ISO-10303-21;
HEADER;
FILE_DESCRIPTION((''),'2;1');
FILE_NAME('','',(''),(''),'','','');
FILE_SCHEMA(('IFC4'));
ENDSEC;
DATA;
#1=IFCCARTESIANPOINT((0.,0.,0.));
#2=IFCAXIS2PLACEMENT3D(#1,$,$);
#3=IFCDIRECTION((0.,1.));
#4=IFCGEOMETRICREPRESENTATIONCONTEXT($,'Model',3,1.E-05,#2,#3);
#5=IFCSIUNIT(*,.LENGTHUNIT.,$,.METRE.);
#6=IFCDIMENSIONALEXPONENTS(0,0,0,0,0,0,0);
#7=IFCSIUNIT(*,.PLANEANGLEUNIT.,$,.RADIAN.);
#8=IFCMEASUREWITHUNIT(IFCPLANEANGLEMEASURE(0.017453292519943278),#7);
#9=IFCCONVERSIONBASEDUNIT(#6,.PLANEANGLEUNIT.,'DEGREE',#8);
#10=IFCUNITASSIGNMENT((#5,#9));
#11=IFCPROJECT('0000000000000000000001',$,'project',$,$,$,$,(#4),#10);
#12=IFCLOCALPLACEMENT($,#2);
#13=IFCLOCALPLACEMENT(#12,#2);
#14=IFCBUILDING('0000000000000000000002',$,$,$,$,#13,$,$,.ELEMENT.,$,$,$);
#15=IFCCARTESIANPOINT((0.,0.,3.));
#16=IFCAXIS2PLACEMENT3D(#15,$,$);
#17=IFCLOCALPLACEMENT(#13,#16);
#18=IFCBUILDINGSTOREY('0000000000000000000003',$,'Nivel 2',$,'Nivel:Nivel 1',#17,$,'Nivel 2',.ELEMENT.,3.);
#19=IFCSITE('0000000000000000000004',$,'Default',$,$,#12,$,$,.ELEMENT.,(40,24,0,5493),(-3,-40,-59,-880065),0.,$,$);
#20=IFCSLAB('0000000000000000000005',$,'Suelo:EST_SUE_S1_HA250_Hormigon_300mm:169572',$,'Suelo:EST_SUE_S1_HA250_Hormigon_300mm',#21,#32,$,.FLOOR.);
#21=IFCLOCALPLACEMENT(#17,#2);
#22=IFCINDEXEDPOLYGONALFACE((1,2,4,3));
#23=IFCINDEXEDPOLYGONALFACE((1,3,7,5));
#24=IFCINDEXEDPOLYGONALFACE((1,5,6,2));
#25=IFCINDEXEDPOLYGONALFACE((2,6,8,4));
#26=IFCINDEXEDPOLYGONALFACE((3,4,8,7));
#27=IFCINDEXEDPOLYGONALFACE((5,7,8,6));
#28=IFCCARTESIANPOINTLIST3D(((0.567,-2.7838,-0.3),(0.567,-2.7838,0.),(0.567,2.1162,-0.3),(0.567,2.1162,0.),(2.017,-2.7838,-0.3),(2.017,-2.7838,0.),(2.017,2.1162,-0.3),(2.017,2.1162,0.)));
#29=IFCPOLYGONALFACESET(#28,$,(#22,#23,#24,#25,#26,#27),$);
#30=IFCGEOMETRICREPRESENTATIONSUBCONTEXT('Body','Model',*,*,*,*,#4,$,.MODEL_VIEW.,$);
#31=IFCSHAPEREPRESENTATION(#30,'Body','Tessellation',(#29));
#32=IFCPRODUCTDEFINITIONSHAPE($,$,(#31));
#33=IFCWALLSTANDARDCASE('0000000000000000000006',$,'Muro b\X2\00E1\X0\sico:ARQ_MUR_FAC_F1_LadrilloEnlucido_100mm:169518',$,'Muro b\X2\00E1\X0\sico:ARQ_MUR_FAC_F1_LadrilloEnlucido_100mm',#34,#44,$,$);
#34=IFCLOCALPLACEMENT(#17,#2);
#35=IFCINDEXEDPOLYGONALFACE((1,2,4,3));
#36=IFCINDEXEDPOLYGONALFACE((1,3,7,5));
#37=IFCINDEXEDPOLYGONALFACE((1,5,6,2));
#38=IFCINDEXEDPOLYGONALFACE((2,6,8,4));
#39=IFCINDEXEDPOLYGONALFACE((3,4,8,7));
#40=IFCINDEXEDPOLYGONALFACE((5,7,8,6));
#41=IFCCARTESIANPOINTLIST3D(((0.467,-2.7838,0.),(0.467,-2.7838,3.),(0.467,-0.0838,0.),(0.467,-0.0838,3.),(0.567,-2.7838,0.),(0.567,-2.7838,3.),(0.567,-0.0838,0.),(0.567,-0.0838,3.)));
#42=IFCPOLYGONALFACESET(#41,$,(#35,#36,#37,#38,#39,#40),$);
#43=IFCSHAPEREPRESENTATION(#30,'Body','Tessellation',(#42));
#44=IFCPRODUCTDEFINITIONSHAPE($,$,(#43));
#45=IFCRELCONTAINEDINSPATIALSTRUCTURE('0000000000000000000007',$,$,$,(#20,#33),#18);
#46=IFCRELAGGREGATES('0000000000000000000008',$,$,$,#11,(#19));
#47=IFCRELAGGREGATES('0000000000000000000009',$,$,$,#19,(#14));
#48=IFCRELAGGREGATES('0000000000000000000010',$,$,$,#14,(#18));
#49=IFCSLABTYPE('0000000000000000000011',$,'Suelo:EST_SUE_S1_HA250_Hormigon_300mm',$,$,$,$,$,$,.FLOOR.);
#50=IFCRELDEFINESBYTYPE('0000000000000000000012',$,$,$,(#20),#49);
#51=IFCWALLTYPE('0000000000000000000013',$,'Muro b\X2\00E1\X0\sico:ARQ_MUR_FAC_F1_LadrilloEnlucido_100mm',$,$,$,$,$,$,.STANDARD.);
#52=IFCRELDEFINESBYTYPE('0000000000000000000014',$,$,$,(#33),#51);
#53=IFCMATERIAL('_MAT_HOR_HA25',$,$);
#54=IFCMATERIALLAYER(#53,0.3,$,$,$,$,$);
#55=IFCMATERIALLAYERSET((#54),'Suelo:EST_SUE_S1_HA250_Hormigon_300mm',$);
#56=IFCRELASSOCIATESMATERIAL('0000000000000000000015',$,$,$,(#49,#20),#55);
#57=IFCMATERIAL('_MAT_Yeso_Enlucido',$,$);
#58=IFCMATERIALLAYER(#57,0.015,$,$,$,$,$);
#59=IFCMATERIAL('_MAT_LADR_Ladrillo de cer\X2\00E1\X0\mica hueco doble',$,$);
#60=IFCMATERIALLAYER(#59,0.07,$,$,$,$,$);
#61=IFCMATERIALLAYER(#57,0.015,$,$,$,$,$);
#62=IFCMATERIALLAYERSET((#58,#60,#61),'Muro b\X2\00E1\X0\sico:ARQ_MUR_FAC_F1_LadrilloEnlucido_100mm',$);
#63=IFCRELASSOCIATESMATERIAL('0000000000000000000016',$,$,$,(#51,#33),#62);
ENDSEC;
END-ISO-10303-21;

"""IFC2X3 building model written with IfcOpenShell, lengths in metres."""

from ifc_helpers import new_model, entity, si_unit, converted_unit, direction, frame, frame_2d, origin, place, context, subcontext, project, spatial, rectangle, extrude, material, layer, layer_set, layer_usage, type_object, element, save


model = new_model("IFC2X3")

# Units and contexts
model_context = context("Model", 3, precision=1e-05, world=origin(), true_north=direction((0.0, 1.0)))
body_context = subcontext(model_context, "Body", "Model", "MODEL_VIEW")
ifc_project = project(units=[si_unit("LENGTHUNIT", "METRE"), converted_unit("PLANEANGLEUNIT", "DEGREE", entity("IfcPlaneAngleMeasure", 0.017453292519943278), si_unit("PLANEANGLEUNIT", "RADIAN"), dimensions=[0, 0, 0, 0, 0, 0, 0])], contexts=[model_context])

# Site, building, storey
site_placement = place(None, origin())
site = spatial("IfcSite", under=ifc_project, at=site_placement, Name="Default", CompositionType="ELEMENT", RefLatitude=(40, 24, 0, 5493), RefLongitude=(-3, -40, -59, -880065), RefElevation=0.0)
building_placement = place(site_placement, origin())
building = spatial("IfcBuilding", under=site, at=building_placement, CompositionType="ELEMENT")
storey_placement = place(building_placement, frame((0.0, 0.0, 3.0)))
storey = spatial("IfcBuildingStorey", under=building, at=storey_placement, Name="Nivel 2", ObjectType="Nivel:Nivel 1", LongName="Nivel 2", CompositionType="ELEMENT", Elevation=3.0)

# Slab
ifc_material_1 = material(Name="_MAT_HOR_HA25")
ifc_layer_1 = layer(ifc_material_1, 0.3)
ifc_layer_set_1 = layer_set([ifc_layer_1], Name="Suelo:EST_SUE_S1_HA250_Hormigon_300mm")
ifc_layer_usage_1 = layer_usage(ifc_layer_set_1, "AXIS3", "POSITIVE", 0.0)
slab_type = type_object("IfcSlabType", Name="Suelo:EST_SUE_S1_HA250_Hormigon_300mm", PredefinedType="FLOOR", material=ifc_layer_set_1)
slab_placement = place(storey_placement, origin())
element("IfcSlab", 1, at=slab_placement, inside=storey, type_object=slab_type, material=ifc_layer_usage_1, Name="Suelo:EST_SUE_S1_HA250_Hormigon_300mm:169572", ObjectType="Suelo:EST_SUE_S1_HA250_Hormigon_300mm", PredefinedType="FLOOR", context=body_context, shape_type="SweptSolid", body=[
    extrude(rectangle(XDim=4.9, YDim=1.45, at=frame_2d((0.0, 0.0), x_axis=(1.0, 0.0))), frame((1.292, -0.3338, 0.0), z_axis=(0.0, 0.0, -1.0), x_axis=(0.0, 1.0, 0.0)), (0.0, 0.0, 1.0), 0.3),
])

# Wall
ifc_material_2 = material(Name="_MAT_Yeso_Enlucido")
ifc_layer_2 = layer(ifc_material_2, 0.015)
ifc_material_3 = material(Name="_MAT_LADR_Ladrillo de cerámica hueco doble")
ifc_layer_3 = layer(ifc_material_3, 0.07)
ifc_layer_4 = layer(ifc_material_2, 0.015)
ifc_layer_set_2 = layer_set([ifc_layer_2, ifc_layer_3, ifc_layer_4], Name="Muro básico:ARQ_MUR_FAC_F1_LadrilloEnlucido_100mm")
ifc_layer_usage_2 = layer_usage(ifc_layer_set_2, "AXIS2", "NEGATIVE", 0.05)
wall_type = type_object("IfcWallType", Name="Muro básico:ARQ_MUR_FAC_F1_LadrilloEnlucido_100mm", PredefinedType="STANDARD", material=ifc_layer_set_2)
wall_placement = place(storey_placement, frame((0.517, -2.7838, 0.0), z_axis=(0.0, 0.0, 1.0), x_axis=(0.0, 1.0, 0.0)))
element("IfcWallStandardCase", 2, at=wall_placement, inside=storey, type_object=wall_type, material=ifc_layer_usage_2, Name="Muro básico:ARQ_MUR_FAC_F1_LadrilloEnlucido_100mm:169518", ObjectType="Muro básico:ARQ_MUR_FAC_F1_LadrilloEnlucido_100mm", context=body_context, shape_type="SweptSolid", body=[
    extrude(rectangle(XDim=2.7, YDim=0.1, at=frame_2d((1.35, 0.0), x_axis=(-1.0, 0.0))), origin(), (0.0, 0.0, 1.0), 3.0),
])

save(model, "model.ifc")
